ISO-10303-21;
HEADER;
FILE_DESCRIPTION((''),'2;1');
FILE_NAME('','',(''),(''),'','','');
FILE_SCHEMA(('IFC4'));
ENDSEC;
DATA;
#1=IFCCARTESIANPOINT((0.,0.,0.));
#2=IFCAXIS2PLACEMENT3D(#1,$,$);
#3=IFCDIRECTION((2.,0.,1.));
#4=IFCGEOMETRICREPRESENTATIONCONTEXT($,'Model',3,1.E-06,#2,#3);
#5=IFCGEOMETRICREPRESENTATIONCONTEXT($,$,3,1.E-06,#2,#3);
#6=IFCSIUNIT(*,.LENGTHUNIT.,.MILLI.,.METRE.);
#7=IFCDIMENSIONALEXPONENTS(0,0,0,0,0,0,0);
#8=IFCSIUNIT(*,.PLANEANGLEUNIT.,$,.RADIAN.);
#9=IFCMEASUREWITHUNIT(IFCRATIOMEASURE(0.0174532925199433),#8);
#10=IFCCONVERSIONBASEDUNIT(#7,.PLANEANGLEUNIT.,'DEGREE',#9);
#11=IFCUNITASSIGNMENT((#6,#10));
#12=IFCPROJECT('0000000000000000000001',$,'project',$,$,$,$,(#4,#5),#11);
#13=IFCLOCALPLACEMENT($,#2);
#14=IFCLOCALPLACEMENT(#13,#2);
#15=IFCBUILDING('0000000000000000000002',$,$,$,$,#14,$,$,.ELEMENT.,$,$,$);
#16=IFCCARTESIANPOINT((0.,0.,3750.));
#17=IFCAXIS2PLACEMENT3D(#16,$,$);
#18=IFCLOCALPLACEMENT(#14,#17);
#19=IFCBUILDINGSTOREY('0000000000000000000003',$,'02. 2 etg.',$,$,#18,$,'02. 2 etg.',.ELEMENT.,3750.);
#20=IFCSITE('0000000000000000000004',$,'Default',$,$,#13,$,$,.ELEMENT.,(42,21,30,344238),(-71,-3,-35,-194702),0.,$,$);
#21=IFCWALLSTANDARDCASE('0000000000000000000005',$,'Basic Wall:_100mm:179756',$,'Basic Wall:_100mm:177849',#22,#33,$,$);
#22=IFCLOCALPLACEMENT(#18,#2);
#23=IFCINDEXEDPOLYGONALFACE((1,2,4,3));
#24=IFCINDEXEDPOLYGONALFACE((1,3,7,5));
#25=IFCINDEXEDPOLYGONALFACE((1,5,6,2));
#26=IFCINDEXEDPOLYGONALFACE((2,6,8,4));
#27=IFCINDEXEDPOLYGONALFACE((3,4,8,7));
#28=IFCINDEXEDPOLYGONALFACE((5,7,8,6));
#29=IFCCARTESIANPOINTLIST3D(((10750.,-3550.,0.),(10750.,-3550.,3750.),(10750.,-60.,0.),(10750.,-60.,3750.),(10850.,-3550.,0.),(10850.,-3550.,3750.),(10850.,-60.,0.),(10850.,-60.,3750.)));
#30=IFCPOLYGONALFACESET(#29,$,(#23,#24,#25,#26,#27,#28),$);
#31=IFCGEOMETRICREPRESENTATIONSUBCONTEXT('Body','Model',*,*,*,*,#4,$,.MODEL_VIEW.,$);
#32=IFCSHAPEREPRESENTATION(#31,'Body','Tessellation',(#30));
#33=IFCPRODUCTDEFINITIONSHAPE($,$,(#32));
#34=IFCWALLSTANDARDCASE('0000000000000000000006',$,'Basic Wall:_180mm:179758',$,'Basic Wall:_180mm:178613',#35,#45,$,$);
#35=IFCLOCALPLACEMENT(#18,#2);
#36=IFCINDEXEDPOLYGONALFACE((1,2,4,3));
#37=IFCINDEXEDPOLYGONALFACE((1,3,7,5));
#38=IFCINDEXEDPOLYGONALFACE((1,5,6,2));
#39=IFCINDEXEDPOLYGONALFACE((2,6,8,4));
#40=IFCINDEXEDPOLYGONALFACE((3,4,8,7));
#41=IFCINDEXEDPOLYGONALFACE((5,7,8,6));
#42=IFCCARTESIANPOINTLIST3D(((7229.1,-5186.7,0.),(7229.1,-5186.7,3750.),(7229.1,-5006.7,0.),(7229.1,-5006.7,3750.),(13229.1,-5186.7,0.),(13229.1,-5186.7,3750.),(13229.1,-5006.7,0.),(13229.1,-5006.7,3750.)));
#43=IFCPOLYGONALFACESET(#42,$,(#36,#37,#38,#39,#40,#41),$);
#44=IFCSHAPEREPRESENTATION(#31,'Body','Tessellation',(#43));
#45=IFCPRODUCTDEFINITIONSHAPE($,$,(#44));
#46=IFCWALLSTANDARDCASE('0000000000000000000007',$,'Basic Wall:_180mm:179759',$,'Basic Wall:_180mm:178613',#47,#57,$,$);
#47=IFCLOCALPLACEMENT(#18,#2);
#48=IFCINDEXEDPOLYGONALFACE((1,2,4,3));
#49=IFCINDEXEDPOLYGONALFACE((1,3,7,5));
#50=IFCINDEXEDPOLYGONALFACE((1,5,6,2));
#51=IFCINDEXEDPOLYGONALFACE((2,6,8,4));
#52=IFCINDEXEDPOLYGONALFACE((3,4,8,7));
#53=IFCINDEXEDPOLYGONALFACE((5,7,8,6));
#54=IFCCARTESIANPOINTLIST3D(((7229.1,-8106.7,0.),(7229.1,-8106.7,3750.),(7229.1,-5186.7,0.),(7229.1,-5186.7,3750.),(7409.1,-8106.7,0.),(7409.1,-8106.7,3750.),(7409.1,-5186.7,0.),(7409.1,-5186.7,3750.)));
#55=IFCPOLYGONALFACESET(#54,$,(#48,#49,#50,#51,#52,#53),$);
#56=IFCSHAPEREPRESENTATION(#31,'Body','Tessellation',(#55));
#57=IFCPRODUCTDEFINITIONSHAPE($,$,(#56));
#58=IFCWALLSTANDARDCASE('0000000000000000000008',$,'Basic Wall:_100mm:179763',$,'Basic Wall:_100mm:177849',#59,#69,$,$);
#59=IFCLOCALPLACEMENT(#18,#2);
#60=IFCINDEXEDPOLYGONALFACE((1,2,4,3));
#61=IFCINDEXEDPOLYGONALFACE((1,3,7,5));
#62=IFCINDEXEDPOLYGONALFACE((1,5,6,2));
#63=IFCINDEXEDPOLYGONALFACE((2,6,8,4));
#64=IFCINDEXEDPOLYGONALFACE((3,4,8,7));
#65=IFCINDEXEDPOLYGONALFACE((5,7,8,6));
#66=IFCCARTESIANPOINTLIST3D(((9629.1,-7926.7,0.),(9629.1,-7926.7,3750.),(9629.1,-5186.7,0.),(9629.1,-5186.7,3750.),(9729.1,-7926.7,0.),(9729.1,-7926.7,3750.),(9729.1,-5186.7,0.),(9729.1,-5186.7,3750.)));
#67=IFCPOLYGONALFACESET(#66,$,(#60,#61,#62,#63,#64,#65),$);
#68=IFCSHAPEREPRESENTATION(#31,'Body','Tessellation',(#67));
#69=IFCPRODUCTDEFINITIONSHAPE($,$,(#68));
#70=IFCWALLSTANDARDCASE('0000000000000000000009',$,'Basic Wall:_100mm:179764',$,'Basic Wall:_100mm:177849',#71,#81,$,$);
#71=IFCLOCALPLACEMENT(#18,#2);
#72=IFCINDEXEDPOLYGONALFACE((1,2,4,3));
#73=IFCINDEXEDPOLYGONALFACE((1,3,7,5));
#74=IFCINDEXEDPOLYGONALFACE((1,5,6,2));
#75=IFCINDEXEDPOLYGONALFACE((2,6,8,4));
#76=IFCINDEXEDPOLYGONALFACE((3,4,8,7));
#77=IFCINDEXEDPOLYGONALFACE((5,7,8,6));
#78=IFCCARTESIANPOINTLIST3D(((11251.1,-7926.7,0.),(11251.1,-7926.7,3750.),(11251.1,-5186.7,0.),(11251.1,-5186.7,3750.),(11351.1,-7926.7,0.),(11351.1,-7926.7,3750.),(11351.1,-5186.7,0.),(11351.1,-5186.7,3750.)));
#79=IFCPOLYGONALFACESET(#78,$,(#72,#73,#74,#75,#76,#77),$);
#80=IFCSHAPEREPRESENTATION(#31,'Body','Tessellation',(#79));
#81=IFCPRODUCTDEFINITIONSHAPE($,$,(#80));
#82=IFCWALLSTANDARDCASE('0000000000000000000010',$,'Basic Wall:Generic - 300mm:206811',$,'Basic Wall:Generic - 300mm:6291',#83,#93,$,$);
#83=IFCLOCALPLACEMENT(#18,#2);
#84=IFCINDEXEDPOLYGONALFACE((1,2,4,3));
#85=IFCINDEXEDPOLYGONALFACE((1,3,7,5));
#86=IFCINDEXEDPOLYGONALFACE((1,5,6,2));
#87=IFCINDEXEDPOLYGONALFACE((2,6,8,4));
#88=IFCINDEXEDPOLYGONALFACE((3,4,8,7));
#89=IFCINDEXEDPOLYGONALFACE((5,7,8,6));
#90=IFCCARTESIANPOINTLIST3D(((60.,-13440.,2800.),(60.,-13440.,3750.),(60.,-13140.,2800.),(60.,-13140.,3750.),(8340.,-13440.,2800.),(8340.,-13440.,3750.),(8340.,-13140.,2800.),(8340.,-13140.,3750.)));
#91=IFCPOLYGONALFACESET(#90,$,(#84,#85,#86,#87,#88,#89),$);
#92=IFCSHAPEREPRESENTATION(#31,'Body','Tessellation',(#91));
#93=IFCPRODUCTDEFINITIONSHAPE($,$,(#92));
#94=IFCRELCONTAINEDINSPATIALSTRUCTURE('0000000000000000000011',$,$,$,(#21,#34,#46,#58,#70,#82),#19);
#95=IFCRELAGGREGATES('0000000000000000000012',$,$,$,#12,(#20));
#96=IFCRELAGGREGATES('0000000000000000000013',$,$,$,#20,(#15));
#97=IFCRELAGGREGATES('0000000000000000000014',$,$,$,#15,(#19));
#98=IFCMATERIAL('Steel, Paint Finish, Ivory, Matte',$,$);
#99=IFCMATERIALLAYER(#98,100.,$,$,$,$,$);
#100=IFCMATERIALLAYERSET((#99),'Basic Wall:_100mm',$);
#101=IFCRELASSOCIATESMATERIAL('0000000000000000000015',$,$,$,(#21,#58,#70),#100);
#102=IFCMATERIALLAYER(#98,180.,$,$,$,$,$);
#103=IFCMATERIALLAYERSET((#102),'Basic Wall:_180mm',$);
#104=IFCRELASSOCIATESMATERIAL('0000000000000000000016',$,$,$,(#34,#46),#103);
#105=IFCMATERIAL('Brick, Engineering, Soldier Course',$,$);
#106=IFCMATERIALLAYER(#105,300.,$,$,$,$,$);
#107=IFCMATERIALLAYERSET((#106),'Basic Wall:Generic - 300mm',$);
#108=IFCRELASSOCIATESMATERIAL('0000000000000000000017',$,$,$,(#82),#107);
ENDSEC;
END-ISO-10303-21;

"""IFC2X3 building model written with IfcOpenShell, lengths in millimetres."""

from ifc_helpers import new_model, entity, si_unit, converted_unit, direction, frame, frame_2d, origin, place, context, subcontext, project, spatial, rectangle, extrude, material, layer, layer_set, layer_usage, element, save


model = new_model("IFC2X3")

# Units and contexts
model_context = context("Model", 3, precision=1e-06, world=origin(), true_north=direction((2.0, 0.0, 1.0)))
context_of_model = context(None, 3, precision=1e-06, world=origin(), true_north=direction((2.0, 0.0, 1.0)))
body_context = subcontext(model_context, "Body", "Model", "MODEL_VIEW")
ifc_project = project(units=[si_unit("LENGTHUNIT", "METRE", prefix="MILLI"), converted_unit("PLANEANGLEUNIT", "DEGREE", entity("IfcRatioMeasure", 0.0174532925199433), si_unit("PLANEANGLEUNIT", "RADIAN"), dimensions=[0, 0, 0, 0, 0, 0, 0])], contexts=[model_context, context_of_model])

# Site, building, storey
site_placement = place(None, origin())
site = spatial("IfcSite", under=ifc_project, at=site_placement, Name="Default", CompositionType="ELEMENT", RefLatitude=(42, 21, 30, 344238), RefLongitude=(-71, -3, -35, -194702), RefElevation=0.0)
building_placement = place(site_placement, origin())
building = spatial("IfcBuilding", under=site, at=building_placement, CompositionType="ELEMENT")
storey_placement = place(building_placement, frame((0.0, 0.0, 3750.0)))
storey = spatial("IfcBuildingStorey", under=building, at=storey_placement, Name="02. 2 etg.", LongName="02. 2 etg.", CompositionType="ELEMENT", Elevation=3750.0)

# Shared definitions
ifc_material_1 = material(Name="Steel, Paint Finish, Ivory, Matte")
ifc_layer_1 = layer(ifc_material_1, 100.0)
ifc_layer_set_1 = layer_set([ifc_layer_1], Name="Basic Wall:_100mm")

# Walls
ifc_layer_usage_1 = layer_usage(ifc_layer_set_1, "AXIS2", "NEGATIVE", 50.0)
wall_1_placement = place(storey_placement, frame((10800.0, -3550.0, 0.0), z_axis=(0.0, 0.0, 1.0), x_axis=(0.0, 1.0, 0.0)))
element("IfcWallStandardCase", 1, at=wall_1_placement, inside=storey, material=ifc_layer_usage_1, Name="Basic Wall:_100mm:179756", ObjectType="Basic Wall:_100mm:177849", context=body_context, shape_type="SweptSolid", body=[
    extrude(rectangle(XDim=3490.0, YDim=100.0, at=frame_2d((1745.0, 0.0), x_axis=(-1.0, 0.0))), origin(), (0.0, 0.0, 1.0), 3750.0),
])
ifc_layer_2 = layer(ifc_material_1, 180.0)
ifc_layer_set_2 = layer_set([ifc_layer_2], Name="Basic Wall:_180mm")
ifc_layer_usage_2 = layer_usage(ifc_layer_set_2, "AXIS2", "NEGATIVE", 90.0)
wall_2_placement = place(storey_placement, frame((7229.1, -5096.7, 0.0)))
element("IfcWallStandardCase", 2, at=wall_2_placement, inside=storey, material=ifc_layer_usage_2, Name="Basic Wall:_180mm:179758", ObjectType="Basic Wall:_180mm:178613", context=body_context, shape_type="SweptSolid", body=[
    extrude(rectangle(XDim=6000.0, YDim=180.0, at=frame_2d((3000.0, 0.0), x_axis=(-1.0, 0.0))), origin(), (0.0, 0.0, 1.0), 3750.0),
])
ifc_layer_usage_3 = layer_usage(ifc_layer_set_2, "AXIS2", "NEGATIVE", 90.0)
wall_3_placement = place(storey_placement, frame((7319.1, -8106.7, 0.0), z_axis=(0.0, 0.0, 1.0), x_axis=(0.0, 1.0, 0.0)))
element("IfcWallStandardCase", 3, at=wall_3_placement, inside=storey, material=ifc_layer_usage_3, Name="Basic Wall:_180mm:179759", ObjectType="Basic Wall:_180mm:178613", context=body_context, shape_type="SweptSolid", body=[
    extrude(rectangle(XDim=2920.0, YDim=180.0, at=frame_2d((1460.0, 0.0), x_axis=(-1.0, 0.0))), origin(), (0.0, 0.0, 1.0), 3750.0),
])
ifc_layer_usage_4 = layer_usage(ifc_layer_set_1, "AXIS2", "POSITIVE", -50.0)
wall_4_placement = place(storey_placement, frame((9679.1, -5186.7, 0.0), z_axis=(0.0, 0.0, 1.0), x_axis=(0.0, -1.0, 0.0)))
element("IfcWallStandardCase", 4, at=wall_4_placement, inside=storey, material=ifc_layer_usage_4, Name="Basic Wall:_100mm:179763", ObjectType="Basic Wall:_100mm:177849", context=body_context, shape_type="SweptSolid", body=[
    extrude(rectangle(XDim=2740.0, YDim=100.0, at=frame_2d((1370.0, 0.0), x_axis=(-1.0, 0.0))), origin(), (0.0, 0.0, 1.0), 3750.0),
])
ifc_layer_usage_5 = layer_usage(ifc_layer_set_1, "AXIS2", "NEGATIVE", 50.0)
wall_5_placement = place(storey_placement, frame((11301.1, -5186.7, 0.0), z_axis=(0.0, 0.0, 1.0), x_axis=(0.0, -1.0, 0.0)))
element("IfcWallStandardCase", 5, at=wall_5_placement, inside=storey, material=ifc_layer_usage_5, Name="Basic Wall:_100mm:179764", ObjectType="Basic Wall:_100mm:177849", context=body_context, shape_type="SweptSolid", body=[
    extrude(rectangle(XDim=2740.0, YDim=100.0, at=frame_2d((1370.0, 0.0), x_axis=(-1.0, 0.0))), origin(), (0.0, 0.0, 1.0), 3750.0),
])
ifc_material_2 = material(Name="Brick, Engineering, Soldier Course")
ifc_layer_3 = layer(ifc_material_2, 300.0)
ifc_layer_set_3 = layer_set([ifc_layer_3], Name="Basic Wall:Generic - 300mm")
ifc_layer_usage_6 = layer_usage(ifc_layer_set_3, "AXIS2", "POSITIVE", -150.0)
wall_6_placement = place(storey_placement, frame((8340.0, -13290.0, 2800.0), z_axis=(0.0, 0.0, 1.0), x_axis=(-1.0, 0.0, 0.0)))
element("IfcWallStandardCase", 6, at=wall_6_placement, inside=storey, material=ifc_layer_usage_6, Name="Basic Wall:Generic - 300mm:206811", ObjectType="Basic Wall:Generic - 300mm:6291", context=body_context, shape_type="SweptSolid", body=[
    extrude(rectangle(XDim=8280.0, YDim=300.0, at=frame_2d((4140.0, 0.0), x_axis=(-1.0, 0.0))), origin(), (0.0, 0.0, 1.0), 950.0),
])

save(model, "model.ifc")
